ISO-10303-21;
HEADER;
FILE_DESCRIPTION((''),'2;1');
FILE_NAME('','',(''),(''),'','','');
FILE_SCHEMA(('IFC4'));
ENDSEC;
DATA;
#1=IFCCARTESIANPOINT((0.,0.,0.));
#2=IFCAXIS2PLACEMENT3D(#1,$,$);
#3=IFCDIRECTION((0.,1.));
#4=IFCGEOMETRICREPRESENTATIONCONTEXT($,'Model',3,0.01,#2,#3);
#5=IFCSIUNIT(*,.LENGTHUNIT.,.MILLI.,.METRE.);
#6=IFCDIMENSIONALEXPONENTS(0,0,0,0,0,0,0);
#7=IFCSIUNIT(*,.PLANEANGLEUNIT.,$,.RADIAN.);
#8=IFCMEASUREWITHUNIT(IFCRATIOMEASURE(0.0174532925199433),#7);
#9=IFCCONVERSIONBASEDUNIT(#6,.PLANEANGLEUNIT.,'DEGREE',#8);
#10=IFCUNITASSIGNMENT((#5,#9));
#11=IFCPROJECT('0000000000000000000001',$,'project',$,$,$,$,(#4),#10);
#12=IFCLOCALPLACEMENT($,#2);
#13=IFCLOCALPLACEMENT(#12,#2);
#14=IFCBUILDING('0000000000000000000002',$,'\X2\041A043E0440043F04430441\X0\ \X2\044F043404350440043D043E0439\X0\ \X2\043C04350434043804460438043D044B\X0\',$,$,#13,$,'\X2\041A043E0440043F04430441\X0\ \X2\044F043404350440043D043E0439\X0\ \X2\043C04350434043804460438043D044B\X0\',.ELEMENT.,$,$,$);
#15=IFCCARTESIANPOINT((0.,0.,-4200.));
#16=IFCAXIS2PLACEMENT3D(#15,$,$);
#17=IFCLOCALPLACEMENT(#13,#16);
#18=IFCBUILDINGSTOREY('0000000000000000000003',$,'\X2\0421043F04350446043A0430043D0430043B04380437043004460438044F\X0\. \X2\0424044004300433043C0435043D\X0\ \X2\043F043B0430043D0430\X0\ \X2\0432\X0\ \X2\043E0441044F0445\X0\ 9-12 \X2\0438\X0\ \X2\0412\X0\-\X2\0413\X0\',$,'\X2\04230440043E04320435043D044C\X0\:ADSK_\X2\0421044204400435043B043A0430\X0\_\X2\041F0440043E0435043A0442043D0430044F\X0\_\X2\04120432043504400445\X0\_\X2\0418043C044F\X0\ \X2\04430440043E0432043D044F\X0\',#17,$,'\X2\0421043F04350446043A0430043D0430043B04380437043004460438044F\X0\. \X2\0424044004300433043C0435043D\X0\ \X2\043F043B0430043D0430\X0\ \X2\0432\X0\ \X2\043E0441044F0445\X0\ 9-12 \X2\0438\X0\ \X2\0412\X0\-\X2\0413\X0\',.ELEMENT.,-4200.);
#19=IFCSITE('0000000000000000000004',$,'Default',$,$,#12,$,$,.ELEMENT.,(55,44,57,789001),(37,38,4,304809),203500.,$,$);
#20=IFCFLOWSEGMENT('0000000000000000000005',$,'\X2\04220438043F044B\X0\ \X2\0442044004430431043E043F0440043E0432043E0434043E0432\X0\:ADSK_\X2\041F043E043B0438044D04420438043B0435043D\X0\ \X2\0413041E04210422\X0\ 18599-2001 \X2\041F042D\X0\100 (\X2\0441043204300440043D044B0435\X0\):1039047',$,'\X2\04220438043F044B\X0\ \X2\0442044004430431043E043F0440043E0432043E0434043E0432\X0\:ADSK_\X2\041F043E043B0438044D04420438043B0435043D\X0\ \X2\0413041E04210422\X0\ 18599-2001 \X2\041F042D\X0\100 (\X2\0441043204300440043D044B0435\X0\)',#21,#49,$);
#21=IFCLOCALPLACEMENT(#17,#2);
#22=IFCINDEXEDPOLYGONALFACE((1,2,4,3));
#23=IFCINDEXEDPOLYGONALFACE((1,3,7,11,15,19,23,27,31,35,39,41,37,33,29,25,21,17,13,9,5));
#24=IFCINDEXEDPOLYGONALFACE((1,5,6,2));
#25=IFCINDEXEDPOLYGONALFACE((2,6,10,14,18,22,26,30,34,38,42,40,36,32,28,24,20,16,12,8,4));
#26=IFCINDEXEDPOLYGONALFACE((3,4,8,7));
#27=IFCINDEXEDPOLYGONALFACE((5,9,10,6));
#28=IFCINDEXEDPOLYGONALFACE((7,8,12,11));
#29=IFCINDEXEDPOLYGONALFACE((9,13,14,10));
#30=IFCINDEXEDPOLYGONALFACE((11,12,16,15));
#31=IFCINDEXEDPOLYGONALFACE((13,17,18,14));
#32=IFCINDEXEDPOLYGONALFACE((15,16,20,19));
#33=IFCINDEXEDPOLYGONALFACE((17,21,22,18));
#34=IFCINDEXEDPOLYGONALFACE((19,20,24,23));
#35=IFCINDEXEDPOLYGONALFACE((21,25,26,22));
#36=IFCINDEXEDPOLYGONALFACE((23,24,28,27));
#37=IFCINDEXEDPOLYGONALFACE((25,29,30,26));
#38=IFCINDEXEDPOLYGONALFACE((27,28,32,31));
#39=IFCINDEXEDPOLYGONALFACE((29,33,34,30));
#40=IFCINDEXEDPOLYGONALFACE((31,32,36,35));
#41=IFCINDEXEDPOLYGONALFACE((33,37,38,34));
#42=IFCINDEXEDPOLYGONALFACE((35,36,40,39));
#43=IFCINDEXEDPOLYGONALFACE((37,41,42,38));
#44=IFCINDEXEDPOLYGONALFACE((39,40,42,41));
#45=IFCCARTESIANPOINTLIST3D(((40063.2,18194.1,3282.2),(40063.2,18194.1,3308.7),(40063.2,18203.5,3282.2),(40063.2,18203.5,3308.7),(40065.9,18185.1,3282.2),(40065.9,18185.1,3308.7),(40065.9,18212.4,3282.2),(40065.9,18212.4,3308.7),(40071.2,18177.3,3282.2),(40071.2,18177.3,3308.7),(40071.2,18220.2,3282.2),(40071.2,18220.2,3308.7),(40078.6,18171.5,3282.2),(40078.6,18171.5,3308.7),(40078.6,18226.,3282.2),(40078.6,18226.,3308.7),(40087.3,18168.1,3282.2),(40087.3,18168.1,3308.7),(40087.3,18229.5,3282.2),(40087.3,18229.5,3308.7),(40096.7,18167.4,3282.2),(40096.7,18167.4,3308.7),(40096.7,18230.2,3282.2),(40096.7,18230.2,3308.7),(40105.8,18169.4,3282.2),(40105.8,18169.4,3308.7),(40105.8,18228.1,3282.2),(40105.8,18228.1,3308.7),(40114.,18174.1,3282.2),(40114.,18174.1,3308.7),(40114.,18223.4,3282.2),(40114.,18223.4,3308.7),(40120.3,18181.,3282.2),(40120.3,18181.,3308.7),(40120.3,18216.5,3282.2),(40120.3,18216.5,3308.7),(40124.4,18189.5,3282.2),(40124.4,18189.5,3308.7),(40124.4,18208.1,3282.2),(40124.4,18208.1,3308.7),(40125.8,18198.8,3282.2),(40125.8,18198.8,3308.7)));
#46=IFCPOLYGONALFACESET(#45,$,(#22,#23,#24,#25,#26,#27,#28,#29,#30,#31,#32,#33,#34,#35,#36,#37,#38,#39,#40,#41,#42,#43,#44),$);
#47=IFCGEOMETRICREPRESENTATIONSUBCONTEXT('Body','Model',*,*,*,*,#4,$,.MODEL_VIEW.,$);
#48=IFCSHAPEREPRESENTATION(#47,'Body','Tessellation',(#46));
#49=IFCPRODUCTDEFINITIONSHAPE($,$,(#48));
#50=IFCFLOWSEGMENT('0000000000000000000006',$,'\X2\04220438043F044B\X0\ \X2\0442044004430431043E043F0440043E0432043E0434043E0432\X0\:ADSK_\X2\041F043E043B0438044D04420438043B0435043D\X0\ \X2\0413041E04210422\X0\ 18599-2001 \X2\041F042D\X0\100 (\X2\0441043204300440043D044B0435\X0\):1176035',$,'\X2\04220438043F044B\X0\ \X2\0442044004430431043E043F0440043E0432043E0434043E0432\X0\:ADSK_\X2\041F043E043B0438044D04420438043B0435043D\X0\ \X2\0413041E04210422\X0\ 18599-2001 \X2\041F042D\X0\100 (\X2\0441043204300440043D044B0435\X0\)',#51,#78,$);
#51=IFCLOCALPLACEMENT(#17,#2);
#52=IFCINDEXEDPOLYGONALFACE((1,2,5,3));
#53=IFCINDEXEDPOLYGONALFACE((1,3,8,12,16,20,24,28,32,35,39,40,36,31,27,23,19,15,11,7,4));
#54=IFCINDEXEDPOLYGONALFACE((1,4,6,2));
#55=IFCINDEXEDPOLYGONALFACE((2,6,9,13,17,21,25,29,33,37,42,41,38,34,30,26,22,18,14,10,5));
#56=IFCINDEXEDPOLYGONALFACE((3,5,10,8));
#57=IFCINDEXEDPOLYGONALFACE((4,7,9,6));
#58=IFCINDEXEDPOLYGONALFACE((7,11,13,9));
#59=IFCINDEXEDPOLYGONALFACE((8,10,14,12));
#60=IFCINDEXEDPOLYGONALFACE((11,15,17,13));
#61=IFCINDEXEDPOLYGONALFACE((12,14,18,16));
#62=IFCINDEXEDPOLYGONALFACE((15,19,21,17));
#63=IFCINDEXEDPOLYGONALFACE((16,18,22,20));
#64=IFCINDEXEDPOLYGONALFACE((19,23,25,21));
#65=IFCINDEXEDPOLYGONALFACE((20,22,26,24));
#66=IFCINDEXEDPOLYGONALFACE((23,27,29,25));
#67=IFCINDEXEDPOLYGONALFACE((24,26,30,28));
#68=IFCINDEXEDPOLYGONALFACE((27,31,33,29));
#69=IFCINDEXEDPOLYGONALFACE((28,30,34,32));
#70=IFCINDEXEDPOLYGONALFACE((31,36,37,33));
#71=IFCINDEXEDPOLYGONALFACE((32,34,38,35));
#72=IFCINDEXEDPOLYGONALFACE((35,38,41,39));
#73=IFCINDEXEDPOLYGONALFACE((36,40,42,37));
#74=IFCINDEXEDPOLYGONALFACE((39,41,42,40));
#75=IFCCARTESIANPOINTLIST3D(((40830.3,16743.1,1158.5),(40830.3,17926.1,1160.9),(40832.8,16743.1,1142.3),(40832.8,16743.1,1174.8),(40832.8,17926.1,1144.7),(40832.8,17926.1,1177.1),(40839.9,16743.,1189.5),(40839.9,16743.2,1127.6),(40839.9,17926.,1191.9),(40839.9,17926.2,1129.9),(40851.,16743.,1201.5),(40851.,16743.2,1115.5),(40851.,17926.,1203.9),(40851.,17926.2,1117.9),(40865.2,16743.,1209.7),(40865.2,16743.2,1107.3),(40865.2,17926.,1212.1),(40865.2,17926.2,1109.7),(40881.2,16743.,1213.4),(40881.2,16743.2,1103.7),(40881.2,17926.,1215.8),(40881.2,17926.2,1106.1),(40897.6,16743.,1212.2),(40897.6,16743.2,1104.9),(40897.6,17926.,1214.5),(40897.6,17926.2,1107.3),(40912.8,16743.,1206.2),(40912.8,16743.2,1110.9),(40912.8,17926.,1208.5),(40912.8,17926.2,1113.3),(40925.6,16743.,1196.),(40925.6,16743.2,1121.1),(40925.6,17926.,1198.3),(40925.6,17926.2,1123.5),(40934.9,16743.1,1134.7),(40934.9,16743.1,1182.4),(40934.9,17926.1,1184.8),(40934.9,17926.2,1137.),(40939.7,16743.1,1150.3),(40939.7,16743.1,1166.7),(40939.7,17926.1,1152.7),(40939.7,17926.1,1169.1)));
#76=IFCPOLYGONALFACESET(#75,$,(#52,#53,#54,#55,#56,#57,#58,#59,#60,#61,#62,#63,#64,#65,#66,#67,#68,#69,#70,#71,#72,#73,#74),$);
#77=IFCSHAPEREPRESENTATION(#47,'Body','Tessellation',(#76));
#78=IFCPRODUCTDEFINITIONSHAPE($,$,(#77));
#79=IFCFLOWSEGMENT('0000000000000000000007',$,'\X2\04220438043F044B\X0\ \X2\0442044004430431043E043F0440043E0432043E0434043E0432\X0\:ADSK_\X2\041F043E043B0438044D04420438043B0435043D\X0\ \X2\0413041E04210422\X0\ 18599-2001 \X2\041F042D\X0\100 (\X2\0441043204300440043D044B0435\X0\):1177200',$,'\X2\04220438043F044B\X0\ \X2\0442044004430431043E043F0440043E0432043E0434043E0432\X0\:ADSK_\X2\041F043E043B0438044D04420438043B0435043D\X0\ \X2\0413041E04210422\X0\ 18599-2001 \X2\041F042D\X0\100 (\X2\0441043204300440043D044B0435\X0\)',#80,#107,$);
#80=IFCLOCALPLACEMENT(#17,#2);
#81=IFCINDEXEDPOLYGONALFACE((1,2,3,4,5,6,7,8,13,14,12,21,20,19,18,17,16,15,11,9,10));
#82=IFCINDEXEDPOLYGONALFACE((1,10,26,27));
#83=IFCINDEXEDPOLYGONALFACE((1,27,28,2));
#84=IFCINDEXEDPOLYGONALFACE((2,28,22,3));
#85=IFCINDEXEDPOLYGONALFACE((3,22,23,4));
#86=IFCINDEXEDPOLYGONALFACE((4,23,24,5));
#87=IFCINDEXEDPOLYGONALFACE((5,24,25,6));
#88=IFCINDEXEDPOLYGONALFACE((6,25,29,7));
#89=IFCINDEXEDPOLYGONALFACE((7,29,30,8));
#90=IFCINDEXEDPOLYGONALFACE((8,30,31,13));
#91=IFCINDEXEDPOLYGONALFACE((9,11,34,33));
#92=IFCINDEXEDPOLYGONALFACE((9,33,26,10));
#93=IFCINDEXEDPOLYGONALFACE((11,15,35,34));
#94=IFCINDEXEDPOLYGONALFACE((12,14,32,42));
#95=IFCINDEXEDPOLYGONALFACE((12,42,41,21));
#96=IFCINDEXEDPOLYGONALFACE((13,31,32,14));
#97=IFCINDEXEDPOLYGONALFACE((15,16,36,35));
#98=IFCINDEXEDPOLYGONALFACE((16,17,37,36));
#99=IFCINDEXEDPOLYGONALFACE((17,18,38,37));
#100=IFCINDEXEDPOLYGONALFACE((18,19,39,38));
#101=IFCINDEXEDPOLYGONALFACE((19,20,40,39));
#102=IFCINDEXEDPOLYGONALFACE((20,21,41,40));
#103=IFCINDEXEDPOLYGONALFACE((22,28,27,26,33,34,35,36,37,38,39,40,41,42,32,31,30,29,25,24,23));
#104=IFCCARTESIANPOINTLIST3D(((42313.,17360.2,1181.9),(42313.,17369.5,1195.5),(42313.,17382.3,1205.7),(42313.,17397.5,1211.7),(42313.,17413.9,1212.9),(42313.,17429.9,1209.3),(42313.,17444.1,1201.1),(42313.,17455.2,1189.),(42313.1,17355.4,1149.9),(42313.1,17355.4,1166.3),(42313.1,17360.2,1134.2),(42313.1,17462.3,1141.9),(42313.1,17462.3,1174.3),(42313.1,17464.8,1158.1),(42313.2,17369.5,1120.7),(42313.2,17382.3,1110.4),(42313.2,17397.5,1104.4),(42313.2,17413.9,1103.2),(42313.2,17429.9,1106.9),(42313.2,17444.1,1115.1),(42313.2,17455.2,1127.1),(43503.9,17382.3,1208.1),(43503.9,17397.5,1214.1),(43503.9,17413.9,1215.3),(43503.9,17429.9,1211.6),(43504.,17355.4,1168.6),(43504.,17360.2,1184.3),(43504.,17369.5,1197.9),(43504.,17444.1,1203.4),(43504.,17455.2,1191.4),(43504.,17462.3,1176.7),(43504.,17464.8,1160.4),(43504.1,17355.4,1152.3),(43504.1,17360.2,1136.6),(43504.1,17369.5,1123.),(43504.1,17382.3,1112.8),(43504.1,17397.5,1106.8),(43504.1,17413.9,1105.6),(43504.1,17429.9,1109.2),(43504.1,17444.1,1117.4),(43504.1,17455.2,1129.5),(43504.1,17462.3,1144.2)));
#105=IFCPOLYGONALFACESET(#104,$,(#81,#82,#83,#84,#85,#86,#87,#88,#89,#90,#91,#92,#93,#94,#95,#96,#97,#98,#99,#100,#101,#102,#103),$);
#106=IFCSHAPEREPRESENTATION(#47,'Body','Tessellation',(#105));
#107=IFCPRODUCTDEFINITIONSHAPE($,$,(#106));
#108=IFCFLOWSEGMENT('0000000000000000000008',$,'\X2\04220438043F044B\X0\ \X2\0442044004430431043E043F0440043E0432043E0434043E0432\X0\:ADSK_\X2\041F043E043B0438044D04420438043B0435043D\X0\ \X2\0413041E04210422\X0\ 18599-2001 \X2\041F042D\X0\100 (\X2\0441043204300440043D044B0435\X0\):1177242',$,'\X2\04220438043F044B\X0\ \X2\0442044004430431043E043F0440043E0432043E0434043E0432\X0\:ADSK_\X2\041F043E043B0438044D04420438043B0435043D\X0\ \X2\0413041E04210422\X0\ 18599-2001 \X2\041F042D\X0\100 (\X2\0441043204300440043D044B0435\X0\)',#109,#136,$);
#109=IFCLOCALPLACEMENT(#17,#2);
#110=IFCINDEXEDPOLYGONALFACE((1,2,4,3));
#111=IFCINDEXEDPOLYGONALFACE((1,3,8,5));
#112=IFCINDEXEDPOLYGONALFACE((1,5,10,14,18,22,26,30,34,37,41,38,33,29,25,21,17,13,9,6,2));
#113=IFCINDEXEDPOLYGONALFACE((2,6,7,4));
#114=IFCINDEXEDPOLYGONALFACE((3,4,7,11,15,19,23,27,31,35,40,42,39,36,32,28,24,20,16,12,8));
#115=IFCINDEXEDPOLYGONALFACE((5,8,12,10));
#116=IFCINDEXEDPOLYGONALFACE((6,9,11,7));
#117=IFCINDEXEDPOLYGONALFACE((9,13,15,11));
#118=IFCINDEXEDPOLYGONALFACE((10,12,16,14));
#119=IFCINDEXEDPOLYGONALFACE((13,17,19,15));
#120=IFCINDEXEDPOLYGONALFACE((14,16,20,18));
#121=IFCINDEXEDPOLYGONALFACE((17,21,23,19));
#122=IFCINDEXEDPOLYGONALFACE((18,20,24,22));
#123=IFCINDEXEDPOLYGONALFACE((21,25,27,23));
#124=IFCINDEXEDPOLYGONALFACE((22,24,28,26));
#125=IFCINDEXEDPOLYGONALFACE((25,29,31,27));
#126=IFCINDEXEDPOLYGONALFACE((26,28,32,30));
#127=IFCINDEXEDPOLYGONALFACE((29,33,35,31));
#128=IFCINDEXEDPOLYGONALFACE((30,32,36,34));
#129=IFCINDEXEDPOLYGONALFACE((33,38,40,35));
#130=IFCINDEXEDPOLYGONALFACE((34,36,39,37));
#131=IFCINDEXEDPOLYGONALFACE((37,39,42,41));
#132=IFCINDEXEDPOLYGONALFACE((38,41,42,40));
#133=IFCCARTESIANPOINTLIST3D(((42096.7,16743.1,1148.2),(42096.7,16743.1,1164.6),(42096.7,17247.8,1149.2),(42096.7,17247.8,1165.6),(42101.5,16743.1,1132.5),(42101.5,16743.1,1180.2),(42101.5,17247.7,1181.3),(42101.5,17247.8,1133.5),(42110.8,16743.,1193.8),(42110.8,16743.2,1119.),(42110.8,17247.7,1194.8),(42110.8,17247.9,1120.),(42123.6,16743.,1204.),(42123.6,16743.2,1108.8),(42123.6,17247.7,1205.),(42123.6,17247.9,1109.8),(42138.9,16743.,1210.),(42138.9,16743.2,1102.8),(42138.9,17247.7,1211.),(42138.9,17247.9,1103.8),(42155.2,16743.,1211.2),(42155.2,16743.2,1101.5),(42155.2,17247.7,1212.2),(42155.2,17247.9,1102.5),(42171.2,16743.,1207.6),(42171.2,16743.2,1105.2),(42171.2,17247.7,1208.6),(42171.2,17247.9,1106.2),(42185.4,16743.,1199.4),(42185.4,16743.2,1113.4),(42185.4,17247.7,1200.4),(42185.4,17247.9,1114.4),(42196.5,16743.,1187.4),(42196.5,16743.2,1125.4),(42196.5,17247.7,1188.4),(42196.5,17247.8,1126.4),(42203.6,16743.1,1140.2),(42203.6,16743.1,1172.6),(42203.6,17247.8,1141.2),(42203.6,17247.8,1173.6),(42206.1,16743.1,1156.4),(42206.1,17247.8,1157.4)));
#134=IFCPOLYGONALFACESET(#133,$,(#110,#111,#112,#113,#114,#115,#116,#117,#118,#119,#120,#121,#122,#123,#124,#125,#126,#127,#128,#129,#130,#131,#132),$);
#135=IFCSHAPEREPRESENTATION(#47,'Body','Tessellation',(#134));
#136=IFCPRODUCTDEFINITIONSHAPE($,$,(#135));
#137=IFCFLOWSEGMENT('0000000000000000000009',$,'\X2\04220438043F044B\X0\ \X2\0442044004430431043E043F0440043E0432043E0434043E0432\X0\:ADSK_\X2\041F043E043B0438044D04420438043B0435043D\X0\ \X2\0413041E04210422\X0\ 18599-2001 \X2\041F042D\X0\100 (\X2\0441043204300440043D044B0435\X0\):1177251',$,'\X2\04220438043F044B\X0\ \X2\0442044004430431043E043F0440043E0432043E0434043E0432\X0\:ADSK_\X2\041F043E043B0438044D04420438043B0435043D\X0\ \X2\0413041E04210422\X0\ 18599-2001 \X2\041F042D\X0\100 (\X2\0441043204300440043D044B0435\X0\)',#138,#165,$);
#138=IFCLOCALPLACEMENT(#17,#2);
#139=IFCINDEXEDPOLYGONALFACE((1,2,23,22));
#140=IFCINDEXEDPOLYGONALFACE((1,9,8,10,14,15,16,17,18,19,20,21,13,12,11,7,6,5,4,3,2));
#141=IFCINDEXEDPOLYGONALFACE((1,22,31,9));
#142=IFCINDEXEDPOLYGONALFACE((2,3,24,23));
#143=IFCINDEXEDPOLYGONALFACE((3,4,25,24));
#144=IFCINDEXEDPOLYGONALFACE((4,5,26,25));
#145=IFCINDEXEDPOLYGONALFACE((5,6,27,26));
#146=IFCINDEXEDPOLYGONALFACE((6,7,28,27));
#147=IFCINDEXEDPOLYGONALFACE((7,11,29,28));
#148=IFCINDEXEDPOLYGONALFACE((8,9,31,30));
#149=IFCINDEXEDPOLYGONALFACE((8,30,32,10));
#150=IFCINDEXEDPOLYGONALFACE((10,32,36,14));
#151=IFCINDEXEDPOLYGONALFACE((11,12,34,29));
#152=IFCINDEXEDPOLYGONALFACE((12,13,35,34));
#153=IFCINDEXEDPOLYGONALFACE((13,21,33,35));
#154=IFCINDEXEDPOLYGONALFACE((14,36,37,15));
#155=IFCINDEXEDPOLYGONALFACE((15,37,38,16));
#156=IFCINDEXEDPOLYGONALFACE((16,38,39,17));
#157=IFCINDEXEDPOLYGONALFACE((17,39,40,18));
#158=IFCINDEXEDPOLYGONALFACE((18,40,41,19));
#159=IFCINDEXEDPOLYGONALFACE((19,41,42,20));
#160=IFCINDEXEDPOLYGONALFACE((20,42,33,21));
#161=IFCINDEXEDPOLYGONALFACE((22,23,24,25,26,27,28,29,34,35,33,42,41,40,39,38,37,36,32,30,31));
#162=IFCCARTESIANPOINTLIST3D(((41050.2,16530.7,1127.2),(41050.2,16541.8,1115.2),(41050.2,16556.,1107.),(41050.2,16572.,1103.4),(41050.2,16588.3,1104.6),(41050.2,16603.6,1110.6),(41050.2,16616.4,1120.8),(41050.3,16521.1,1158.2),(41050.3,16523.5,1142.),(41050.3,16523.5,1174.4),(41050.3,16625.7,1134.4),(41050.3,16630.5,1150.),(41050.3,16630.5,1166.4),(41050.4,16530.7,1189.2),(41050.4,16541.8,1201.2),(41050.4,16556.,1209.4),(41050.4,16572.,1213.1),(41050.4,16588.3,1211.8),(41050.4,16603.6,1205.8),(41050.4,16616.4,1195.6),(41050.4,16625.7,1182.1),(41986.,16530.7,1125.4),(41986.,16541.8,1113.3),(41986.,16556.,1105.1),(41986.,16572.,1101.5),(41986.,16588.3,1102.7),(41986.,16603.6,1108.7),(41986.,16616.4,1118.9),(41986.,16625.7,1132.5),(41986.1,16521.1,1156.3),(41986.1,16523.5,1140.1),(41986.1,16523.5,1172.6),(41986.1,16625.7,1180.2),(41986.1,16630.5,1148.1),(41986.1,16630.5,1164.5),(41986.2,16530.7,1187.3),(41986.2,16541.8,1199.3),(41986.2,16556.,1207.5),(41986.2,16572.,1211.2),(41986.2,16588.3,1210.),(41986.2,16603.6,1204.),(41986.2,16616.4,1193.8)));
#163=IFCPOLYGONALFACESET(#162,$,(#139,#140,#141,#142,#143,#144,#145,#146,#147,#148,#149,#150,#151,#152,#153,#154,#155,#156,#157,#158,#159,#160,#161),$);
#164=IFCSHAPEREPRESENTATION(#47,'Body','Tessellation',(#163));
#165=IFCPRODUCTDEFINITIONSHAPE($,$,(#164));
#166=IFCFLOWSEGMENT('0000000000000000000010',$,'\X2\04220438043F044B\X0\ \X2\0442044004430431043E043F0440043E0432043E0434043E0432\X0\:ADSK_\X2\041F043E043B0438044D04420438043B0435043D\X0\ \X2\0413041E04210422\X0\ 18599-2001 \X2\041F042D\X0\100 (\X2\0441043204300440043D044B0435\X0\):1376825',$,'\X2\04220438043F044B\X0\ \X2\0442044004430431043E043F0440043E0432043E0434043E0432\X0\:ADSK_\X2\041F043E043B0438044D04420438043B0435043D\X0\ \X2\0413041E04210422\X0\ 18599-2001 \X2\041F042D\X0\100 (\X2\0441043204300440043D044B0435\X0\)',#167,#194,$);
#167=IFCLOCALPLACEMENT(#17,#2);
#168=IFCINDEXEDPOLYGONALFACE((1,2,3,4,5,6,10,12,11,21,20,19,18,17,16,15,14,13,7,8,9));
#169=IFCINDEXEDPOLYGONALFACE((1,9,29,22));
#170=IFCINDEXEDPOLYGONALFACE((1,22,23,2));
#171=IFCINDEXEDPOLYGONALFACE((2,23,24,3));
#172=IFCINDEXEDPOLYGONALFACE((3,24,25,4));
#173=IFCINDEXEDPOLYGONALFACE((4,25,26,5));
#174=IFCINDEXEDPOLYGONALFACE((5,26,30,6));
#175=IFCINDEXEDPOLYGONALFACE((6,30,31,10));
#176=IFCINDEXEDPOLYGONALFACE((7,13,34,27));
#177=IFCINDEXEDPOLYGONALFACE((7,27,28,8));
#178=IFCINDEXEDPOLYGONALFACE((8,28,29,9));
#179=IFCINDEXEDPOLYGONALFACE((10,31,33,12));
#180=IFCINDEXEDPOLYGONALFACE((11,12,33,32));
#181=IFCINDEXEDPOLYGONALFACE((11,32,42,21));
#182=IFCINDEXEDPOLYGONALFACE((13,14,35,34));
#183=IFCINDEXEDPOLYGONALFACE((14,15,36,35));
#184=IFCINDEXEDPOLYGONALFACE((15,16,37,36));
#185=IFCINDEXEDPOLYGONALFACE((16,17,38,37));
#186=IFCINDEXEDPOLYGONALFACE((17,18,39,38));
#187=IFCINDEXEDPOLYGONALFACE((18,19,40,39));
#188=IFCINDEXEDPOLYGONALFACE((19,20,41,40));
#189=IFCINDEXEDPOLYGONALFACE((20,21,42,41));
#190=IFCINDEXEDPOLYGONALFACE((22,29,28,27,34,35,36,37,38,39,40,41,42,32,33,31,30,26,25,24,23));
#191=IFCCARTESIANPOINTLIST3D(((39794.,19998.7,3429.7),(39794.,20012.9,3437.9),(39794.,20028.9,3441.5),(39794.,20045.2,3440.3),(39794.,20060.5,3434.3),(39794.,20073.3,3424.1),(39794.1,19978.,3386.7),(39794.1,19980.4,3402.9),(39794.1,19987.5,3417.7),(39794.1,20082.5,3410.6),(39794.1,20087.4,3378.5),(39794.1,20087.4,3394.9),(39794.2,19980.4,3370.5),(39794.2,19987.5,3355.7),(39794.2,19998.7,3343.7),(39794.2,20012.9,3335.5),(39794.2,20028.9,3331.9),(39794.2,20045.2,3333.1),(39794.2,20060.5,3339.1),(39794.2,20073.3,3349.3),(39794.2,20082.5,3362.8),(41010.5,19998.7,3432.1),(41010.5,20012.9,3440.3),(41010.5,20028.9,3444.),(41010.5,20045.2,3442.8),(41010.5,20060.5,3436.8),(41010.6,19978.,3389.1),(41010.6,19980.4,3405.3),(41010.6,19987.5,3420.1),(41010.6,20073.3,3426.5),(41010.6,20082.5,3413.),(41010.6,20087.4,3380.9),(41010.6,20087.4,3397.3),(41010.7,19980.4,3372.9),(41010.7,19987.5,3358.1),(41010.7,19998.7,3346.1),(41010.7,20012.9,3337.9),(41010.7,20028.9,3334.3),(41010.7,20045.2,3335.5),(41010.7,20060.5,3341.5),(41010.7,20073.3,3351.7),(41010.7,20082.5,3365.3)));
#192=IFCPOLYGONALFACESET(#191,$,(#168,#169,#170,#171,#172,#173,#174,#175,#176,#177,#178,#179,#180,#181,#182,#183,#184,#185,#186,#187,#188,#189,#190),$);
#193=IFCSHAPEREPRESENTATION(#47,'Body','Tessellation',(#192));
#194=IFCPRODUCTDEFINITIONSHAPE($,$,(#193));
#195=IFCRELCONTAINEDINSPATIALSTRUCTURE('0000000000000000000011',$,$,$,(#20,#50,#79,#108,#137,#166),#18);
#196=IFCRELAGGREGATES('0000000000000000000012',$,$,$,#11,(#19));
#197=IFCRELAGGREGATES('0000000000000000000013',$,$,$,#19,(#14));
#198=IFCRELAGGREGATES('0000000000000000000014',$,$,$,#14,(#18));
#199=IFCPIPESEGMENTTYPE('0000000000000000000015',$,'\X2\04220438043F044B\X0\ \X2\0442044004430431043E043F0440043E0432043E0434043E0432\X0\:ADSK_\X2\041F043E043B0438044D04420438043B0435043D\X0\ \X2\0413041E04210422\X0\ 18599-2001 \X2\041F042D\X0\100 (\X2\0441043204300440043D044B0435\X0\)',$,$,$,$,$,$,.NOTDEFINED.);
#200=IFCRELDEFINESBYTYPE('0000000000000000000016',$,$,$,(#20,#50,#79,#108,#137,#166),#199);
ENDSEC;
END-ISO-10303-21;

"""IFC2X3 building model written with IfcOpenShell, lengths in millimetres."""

from ifc_helpers import new_model, entity, si_unit, converted_unit, direction, frame, frame_2d, origin, origin_2d_with_axis, place, context, subcontext, project, spatial, circle, extrude, type_object, element, save


model = new_model("IFC2X3")

# Units and contexts
model_context = context("Model", 3, precision=0.01, world=origin(), true_north=direction((0.0, 1.0)))
body_context = subcontext(model_context, "Body", "Model", "MODEL_VIEW")
ifc_project = project(units=[si_unit("LENGTHUNIT", "METRE", prefix="MILLI"), converted_unit("PLANEANGLEUNIT", "DEGREE", entity("IfcRatioMeasure", 0.0174532925199433), si_unit("PLANEANGLEUNIT", "RADIAN"), dimensions=[0, 0, 0, 0, 0, 0, 0])], contexts=[model_context])

# Site, building, storey
site_placement = place(None, frame((0.0, 0.0, 0.0)))
site = spatial("IfcSite", under=ifc_project, at=site_placement, Name="Default", CompositionType="ELEMENT", RefLatitude=(55, 44, 57, 789001), RefLongitude=(37, 38, 4, 304809), RefElevation=203500.0)
building_placement = place(site_placement, origin())
building = spatial("IfcBuilding", under=site, at=building_placement, Name="Корпус ядерной медицины", LongName="Корпус ядерной медицины", CompositionType="ELEMENT")
storey_placement = place(building_placement, frame((0.0, 0.0, -4200.0)))
storey = spatial("IfcBuildingStorey", under=building, at=storey_placement, Name="Спецканализация. Фрагмен плана в осях 9-12 и В-Г", ObjectType="Уровень:ADSK_Стрелка_Проектная_Вверх_Имя уровня", LongName="Спецканализация. Фрагмен плана в осях 9-12 и В-Г", CompositionType="ELEMENT", Elevation=-4200.0)

# Flow segments
pipe_segment_type = type_object("IfcPipeSegmentType", Name="Типы трубопроводов:ADSK_Полиэтилен ГОСТ 18599-2001 ПЭ100 (сварные)", PredefinedType="NOTDEFINED")
flow_segment_1_placement = place(storey_placement, frame((40061.2, 18165.7, 3282.2)))
element("IfcFlowSegment", 1, at=flow_segment_1_placement, inside=storey, type_object=pipe_segment_type, Name="Типы трубопроводов:ADSK_Полиэтилен ГОСТ 18599-2001 ПЭ100 (сварные):1039047", ObjectType="Типы трубопроводов:ADSK_Полиэтилен ГОСТ 18599-2001 ПЭ100 (сварные)", context=body_context, shape_type="SweptSolid", body=[
    extrude(circle(Radius=31.5, at=frame_2d((0.0, 0.0), x_axis=(1.0, 0.0))), frame((33.1, 33.1, 0.0), z_axis=(0.000039, -0.00005, 1.0), x_axis=(1.0, 0.0, -0.000039)), (0.0, 0.0, 1.0), 26.5),
])
flow_segment_2_placement = place(storey_placement, frame((40828.7, 16743.0, 1102.0)))
element("IfcFlowSegment", 2, at=flow_segment_2_placement, inside=storey, type_object=pipe_segment_type, Name="Типы трубопроводов:ADSK_Полиэтилен ГОСТ 18599-2001 ПЭ100 (сварные):1176035", ObjectType="Типы трубопроводов:ADSK_Полиэтилен ГОСТ 18599-2001 ПЭ100 (сварные)", context=body_context, shape_type="SweptSolid", body=[
    extrude(circle(Radius=55.0, at=frame_2d((0.0, 0.0), x_axis=(1.0, 0.0))), frame((56.6, 0.1, 56.6), z_axis=(0.0, 0.999998, 0.002), x_axis=(-1.0, 0.0, 0.0)), (0.0, 0.0, 1.0), 1183.0),
])
flow_segment_3_placement = place(storey_placement, frame((42313.0, 17353.2, 1101.5)))
element("IfcFlowSegment", 3, at=flow_segment_3_placement, inside=storey, type_object=pipe_segment_type, Name="Типы трубопроводов:ADSK_Полиэтилен ГОСТ 18599-2001 ПЭ100 (сварные):1177200", ObjectType="Типы трубопроводов:ADSK_Полиэтилен ГОСТ 18599-2001 ПЭ100 (сварные)", context=body_context, shape_type="SweptSolid", body=[
    extrude(circle(Radius=55.0, at=origin_2d_with_axis()), frame((0.1, 56.6, 56.6), z_axis=(0.999998, 0.0, 0.002), x_axis=(0.0, 1.0, 0.0)), (0.0, 0.0, 1.0), 1191.0),
])
flow_segment_4_placement = place(storey_placement, frame((42094.5, 16743.0, 1099.8)))
element("IfcFlowSegment", 4, at=flow_segment_4_placement, inside=storey, type_object=pipe_segment_type, Name="Типы трубопроводов:ADSK_Полиэтилен ГОСТ 18599-2001 ПЭ100 (сварные):1177242", ObjectType="Типы трубопроводов:ADSK_Полиэтилен ГОСТ 18599-2001 ПЭ100 (сварные)", context=body_context, shape_type="SweptSolid", body=[
    extrude(circle(Radius=55.0, at=origin_2d_with_axis()), frame((56.6, 0.1, 56.6), z_axis=(-0.000001, 0.999998, 0.002), x_axis=(1.0, 0.000001, 0.0)), (0.0, 0.0, 1.0), 504.7),
])
flow_segment_5_placement = place(storey_placement, frame((41050.2, 16519.5, 1099.7)))
element("IfcFlowSegment", 5, at=flow_segment_5_placement, inside=storey, type_object=pipe_segment_type, Name="Типы трубопроводов:ADSK_Полиэтилен ГОСТ 18599-2001 ПЭ100 (сварные):1177251", ObjectType="Типы трубопроводов:ADSK_Полиэтилен ГОСТ 18599-2001 ПЭ100 (сварные)", context=body_context, shape_type="SweptSolid", body=[
    extrude(circle(Radius=55.0, at=origin_2d_with_axis()), frame((0.1, 56.6, 58.5), z_axis=(0.999998, 0.0, -0.002), x_axis=(0.0, -1.0, 0.0)), (0.0, 0.0, 1.0), 935.8),
])
flow_segment_6_placement = place(storey_placement, frame((39794.0, 19976.4, 3330.1)))
element("IfcFlowSegment", 6, at=flow_segment_6_placement, inside=storey, type_object=pipe_segment_type, Name="Типы трубопроводов:ADSK_Полиэтилен ГОСТ 18599-2001 ПЭ100 (сварные):1376825", ObjectType="Типы трубопроводов:ADSK_Полиэтилен ГОСТ 18599-2001 ПЭ100 (сварные)", context=body_context, shape_type="SweptSolid", body=[
    extrude(circle(Radius=55.0, at=frame_2d((0.0, 0.0), x_axis=(1.0, 0.0))), frame((0.1, 56.6, 56.6), z_axis=(0.999998, 0.0, 0.002), x_axis=(0.0, -1.0, 0.0)), (0.0, 0.0, 1.0), 1216.5),
])

save(model, "model.ifc")
